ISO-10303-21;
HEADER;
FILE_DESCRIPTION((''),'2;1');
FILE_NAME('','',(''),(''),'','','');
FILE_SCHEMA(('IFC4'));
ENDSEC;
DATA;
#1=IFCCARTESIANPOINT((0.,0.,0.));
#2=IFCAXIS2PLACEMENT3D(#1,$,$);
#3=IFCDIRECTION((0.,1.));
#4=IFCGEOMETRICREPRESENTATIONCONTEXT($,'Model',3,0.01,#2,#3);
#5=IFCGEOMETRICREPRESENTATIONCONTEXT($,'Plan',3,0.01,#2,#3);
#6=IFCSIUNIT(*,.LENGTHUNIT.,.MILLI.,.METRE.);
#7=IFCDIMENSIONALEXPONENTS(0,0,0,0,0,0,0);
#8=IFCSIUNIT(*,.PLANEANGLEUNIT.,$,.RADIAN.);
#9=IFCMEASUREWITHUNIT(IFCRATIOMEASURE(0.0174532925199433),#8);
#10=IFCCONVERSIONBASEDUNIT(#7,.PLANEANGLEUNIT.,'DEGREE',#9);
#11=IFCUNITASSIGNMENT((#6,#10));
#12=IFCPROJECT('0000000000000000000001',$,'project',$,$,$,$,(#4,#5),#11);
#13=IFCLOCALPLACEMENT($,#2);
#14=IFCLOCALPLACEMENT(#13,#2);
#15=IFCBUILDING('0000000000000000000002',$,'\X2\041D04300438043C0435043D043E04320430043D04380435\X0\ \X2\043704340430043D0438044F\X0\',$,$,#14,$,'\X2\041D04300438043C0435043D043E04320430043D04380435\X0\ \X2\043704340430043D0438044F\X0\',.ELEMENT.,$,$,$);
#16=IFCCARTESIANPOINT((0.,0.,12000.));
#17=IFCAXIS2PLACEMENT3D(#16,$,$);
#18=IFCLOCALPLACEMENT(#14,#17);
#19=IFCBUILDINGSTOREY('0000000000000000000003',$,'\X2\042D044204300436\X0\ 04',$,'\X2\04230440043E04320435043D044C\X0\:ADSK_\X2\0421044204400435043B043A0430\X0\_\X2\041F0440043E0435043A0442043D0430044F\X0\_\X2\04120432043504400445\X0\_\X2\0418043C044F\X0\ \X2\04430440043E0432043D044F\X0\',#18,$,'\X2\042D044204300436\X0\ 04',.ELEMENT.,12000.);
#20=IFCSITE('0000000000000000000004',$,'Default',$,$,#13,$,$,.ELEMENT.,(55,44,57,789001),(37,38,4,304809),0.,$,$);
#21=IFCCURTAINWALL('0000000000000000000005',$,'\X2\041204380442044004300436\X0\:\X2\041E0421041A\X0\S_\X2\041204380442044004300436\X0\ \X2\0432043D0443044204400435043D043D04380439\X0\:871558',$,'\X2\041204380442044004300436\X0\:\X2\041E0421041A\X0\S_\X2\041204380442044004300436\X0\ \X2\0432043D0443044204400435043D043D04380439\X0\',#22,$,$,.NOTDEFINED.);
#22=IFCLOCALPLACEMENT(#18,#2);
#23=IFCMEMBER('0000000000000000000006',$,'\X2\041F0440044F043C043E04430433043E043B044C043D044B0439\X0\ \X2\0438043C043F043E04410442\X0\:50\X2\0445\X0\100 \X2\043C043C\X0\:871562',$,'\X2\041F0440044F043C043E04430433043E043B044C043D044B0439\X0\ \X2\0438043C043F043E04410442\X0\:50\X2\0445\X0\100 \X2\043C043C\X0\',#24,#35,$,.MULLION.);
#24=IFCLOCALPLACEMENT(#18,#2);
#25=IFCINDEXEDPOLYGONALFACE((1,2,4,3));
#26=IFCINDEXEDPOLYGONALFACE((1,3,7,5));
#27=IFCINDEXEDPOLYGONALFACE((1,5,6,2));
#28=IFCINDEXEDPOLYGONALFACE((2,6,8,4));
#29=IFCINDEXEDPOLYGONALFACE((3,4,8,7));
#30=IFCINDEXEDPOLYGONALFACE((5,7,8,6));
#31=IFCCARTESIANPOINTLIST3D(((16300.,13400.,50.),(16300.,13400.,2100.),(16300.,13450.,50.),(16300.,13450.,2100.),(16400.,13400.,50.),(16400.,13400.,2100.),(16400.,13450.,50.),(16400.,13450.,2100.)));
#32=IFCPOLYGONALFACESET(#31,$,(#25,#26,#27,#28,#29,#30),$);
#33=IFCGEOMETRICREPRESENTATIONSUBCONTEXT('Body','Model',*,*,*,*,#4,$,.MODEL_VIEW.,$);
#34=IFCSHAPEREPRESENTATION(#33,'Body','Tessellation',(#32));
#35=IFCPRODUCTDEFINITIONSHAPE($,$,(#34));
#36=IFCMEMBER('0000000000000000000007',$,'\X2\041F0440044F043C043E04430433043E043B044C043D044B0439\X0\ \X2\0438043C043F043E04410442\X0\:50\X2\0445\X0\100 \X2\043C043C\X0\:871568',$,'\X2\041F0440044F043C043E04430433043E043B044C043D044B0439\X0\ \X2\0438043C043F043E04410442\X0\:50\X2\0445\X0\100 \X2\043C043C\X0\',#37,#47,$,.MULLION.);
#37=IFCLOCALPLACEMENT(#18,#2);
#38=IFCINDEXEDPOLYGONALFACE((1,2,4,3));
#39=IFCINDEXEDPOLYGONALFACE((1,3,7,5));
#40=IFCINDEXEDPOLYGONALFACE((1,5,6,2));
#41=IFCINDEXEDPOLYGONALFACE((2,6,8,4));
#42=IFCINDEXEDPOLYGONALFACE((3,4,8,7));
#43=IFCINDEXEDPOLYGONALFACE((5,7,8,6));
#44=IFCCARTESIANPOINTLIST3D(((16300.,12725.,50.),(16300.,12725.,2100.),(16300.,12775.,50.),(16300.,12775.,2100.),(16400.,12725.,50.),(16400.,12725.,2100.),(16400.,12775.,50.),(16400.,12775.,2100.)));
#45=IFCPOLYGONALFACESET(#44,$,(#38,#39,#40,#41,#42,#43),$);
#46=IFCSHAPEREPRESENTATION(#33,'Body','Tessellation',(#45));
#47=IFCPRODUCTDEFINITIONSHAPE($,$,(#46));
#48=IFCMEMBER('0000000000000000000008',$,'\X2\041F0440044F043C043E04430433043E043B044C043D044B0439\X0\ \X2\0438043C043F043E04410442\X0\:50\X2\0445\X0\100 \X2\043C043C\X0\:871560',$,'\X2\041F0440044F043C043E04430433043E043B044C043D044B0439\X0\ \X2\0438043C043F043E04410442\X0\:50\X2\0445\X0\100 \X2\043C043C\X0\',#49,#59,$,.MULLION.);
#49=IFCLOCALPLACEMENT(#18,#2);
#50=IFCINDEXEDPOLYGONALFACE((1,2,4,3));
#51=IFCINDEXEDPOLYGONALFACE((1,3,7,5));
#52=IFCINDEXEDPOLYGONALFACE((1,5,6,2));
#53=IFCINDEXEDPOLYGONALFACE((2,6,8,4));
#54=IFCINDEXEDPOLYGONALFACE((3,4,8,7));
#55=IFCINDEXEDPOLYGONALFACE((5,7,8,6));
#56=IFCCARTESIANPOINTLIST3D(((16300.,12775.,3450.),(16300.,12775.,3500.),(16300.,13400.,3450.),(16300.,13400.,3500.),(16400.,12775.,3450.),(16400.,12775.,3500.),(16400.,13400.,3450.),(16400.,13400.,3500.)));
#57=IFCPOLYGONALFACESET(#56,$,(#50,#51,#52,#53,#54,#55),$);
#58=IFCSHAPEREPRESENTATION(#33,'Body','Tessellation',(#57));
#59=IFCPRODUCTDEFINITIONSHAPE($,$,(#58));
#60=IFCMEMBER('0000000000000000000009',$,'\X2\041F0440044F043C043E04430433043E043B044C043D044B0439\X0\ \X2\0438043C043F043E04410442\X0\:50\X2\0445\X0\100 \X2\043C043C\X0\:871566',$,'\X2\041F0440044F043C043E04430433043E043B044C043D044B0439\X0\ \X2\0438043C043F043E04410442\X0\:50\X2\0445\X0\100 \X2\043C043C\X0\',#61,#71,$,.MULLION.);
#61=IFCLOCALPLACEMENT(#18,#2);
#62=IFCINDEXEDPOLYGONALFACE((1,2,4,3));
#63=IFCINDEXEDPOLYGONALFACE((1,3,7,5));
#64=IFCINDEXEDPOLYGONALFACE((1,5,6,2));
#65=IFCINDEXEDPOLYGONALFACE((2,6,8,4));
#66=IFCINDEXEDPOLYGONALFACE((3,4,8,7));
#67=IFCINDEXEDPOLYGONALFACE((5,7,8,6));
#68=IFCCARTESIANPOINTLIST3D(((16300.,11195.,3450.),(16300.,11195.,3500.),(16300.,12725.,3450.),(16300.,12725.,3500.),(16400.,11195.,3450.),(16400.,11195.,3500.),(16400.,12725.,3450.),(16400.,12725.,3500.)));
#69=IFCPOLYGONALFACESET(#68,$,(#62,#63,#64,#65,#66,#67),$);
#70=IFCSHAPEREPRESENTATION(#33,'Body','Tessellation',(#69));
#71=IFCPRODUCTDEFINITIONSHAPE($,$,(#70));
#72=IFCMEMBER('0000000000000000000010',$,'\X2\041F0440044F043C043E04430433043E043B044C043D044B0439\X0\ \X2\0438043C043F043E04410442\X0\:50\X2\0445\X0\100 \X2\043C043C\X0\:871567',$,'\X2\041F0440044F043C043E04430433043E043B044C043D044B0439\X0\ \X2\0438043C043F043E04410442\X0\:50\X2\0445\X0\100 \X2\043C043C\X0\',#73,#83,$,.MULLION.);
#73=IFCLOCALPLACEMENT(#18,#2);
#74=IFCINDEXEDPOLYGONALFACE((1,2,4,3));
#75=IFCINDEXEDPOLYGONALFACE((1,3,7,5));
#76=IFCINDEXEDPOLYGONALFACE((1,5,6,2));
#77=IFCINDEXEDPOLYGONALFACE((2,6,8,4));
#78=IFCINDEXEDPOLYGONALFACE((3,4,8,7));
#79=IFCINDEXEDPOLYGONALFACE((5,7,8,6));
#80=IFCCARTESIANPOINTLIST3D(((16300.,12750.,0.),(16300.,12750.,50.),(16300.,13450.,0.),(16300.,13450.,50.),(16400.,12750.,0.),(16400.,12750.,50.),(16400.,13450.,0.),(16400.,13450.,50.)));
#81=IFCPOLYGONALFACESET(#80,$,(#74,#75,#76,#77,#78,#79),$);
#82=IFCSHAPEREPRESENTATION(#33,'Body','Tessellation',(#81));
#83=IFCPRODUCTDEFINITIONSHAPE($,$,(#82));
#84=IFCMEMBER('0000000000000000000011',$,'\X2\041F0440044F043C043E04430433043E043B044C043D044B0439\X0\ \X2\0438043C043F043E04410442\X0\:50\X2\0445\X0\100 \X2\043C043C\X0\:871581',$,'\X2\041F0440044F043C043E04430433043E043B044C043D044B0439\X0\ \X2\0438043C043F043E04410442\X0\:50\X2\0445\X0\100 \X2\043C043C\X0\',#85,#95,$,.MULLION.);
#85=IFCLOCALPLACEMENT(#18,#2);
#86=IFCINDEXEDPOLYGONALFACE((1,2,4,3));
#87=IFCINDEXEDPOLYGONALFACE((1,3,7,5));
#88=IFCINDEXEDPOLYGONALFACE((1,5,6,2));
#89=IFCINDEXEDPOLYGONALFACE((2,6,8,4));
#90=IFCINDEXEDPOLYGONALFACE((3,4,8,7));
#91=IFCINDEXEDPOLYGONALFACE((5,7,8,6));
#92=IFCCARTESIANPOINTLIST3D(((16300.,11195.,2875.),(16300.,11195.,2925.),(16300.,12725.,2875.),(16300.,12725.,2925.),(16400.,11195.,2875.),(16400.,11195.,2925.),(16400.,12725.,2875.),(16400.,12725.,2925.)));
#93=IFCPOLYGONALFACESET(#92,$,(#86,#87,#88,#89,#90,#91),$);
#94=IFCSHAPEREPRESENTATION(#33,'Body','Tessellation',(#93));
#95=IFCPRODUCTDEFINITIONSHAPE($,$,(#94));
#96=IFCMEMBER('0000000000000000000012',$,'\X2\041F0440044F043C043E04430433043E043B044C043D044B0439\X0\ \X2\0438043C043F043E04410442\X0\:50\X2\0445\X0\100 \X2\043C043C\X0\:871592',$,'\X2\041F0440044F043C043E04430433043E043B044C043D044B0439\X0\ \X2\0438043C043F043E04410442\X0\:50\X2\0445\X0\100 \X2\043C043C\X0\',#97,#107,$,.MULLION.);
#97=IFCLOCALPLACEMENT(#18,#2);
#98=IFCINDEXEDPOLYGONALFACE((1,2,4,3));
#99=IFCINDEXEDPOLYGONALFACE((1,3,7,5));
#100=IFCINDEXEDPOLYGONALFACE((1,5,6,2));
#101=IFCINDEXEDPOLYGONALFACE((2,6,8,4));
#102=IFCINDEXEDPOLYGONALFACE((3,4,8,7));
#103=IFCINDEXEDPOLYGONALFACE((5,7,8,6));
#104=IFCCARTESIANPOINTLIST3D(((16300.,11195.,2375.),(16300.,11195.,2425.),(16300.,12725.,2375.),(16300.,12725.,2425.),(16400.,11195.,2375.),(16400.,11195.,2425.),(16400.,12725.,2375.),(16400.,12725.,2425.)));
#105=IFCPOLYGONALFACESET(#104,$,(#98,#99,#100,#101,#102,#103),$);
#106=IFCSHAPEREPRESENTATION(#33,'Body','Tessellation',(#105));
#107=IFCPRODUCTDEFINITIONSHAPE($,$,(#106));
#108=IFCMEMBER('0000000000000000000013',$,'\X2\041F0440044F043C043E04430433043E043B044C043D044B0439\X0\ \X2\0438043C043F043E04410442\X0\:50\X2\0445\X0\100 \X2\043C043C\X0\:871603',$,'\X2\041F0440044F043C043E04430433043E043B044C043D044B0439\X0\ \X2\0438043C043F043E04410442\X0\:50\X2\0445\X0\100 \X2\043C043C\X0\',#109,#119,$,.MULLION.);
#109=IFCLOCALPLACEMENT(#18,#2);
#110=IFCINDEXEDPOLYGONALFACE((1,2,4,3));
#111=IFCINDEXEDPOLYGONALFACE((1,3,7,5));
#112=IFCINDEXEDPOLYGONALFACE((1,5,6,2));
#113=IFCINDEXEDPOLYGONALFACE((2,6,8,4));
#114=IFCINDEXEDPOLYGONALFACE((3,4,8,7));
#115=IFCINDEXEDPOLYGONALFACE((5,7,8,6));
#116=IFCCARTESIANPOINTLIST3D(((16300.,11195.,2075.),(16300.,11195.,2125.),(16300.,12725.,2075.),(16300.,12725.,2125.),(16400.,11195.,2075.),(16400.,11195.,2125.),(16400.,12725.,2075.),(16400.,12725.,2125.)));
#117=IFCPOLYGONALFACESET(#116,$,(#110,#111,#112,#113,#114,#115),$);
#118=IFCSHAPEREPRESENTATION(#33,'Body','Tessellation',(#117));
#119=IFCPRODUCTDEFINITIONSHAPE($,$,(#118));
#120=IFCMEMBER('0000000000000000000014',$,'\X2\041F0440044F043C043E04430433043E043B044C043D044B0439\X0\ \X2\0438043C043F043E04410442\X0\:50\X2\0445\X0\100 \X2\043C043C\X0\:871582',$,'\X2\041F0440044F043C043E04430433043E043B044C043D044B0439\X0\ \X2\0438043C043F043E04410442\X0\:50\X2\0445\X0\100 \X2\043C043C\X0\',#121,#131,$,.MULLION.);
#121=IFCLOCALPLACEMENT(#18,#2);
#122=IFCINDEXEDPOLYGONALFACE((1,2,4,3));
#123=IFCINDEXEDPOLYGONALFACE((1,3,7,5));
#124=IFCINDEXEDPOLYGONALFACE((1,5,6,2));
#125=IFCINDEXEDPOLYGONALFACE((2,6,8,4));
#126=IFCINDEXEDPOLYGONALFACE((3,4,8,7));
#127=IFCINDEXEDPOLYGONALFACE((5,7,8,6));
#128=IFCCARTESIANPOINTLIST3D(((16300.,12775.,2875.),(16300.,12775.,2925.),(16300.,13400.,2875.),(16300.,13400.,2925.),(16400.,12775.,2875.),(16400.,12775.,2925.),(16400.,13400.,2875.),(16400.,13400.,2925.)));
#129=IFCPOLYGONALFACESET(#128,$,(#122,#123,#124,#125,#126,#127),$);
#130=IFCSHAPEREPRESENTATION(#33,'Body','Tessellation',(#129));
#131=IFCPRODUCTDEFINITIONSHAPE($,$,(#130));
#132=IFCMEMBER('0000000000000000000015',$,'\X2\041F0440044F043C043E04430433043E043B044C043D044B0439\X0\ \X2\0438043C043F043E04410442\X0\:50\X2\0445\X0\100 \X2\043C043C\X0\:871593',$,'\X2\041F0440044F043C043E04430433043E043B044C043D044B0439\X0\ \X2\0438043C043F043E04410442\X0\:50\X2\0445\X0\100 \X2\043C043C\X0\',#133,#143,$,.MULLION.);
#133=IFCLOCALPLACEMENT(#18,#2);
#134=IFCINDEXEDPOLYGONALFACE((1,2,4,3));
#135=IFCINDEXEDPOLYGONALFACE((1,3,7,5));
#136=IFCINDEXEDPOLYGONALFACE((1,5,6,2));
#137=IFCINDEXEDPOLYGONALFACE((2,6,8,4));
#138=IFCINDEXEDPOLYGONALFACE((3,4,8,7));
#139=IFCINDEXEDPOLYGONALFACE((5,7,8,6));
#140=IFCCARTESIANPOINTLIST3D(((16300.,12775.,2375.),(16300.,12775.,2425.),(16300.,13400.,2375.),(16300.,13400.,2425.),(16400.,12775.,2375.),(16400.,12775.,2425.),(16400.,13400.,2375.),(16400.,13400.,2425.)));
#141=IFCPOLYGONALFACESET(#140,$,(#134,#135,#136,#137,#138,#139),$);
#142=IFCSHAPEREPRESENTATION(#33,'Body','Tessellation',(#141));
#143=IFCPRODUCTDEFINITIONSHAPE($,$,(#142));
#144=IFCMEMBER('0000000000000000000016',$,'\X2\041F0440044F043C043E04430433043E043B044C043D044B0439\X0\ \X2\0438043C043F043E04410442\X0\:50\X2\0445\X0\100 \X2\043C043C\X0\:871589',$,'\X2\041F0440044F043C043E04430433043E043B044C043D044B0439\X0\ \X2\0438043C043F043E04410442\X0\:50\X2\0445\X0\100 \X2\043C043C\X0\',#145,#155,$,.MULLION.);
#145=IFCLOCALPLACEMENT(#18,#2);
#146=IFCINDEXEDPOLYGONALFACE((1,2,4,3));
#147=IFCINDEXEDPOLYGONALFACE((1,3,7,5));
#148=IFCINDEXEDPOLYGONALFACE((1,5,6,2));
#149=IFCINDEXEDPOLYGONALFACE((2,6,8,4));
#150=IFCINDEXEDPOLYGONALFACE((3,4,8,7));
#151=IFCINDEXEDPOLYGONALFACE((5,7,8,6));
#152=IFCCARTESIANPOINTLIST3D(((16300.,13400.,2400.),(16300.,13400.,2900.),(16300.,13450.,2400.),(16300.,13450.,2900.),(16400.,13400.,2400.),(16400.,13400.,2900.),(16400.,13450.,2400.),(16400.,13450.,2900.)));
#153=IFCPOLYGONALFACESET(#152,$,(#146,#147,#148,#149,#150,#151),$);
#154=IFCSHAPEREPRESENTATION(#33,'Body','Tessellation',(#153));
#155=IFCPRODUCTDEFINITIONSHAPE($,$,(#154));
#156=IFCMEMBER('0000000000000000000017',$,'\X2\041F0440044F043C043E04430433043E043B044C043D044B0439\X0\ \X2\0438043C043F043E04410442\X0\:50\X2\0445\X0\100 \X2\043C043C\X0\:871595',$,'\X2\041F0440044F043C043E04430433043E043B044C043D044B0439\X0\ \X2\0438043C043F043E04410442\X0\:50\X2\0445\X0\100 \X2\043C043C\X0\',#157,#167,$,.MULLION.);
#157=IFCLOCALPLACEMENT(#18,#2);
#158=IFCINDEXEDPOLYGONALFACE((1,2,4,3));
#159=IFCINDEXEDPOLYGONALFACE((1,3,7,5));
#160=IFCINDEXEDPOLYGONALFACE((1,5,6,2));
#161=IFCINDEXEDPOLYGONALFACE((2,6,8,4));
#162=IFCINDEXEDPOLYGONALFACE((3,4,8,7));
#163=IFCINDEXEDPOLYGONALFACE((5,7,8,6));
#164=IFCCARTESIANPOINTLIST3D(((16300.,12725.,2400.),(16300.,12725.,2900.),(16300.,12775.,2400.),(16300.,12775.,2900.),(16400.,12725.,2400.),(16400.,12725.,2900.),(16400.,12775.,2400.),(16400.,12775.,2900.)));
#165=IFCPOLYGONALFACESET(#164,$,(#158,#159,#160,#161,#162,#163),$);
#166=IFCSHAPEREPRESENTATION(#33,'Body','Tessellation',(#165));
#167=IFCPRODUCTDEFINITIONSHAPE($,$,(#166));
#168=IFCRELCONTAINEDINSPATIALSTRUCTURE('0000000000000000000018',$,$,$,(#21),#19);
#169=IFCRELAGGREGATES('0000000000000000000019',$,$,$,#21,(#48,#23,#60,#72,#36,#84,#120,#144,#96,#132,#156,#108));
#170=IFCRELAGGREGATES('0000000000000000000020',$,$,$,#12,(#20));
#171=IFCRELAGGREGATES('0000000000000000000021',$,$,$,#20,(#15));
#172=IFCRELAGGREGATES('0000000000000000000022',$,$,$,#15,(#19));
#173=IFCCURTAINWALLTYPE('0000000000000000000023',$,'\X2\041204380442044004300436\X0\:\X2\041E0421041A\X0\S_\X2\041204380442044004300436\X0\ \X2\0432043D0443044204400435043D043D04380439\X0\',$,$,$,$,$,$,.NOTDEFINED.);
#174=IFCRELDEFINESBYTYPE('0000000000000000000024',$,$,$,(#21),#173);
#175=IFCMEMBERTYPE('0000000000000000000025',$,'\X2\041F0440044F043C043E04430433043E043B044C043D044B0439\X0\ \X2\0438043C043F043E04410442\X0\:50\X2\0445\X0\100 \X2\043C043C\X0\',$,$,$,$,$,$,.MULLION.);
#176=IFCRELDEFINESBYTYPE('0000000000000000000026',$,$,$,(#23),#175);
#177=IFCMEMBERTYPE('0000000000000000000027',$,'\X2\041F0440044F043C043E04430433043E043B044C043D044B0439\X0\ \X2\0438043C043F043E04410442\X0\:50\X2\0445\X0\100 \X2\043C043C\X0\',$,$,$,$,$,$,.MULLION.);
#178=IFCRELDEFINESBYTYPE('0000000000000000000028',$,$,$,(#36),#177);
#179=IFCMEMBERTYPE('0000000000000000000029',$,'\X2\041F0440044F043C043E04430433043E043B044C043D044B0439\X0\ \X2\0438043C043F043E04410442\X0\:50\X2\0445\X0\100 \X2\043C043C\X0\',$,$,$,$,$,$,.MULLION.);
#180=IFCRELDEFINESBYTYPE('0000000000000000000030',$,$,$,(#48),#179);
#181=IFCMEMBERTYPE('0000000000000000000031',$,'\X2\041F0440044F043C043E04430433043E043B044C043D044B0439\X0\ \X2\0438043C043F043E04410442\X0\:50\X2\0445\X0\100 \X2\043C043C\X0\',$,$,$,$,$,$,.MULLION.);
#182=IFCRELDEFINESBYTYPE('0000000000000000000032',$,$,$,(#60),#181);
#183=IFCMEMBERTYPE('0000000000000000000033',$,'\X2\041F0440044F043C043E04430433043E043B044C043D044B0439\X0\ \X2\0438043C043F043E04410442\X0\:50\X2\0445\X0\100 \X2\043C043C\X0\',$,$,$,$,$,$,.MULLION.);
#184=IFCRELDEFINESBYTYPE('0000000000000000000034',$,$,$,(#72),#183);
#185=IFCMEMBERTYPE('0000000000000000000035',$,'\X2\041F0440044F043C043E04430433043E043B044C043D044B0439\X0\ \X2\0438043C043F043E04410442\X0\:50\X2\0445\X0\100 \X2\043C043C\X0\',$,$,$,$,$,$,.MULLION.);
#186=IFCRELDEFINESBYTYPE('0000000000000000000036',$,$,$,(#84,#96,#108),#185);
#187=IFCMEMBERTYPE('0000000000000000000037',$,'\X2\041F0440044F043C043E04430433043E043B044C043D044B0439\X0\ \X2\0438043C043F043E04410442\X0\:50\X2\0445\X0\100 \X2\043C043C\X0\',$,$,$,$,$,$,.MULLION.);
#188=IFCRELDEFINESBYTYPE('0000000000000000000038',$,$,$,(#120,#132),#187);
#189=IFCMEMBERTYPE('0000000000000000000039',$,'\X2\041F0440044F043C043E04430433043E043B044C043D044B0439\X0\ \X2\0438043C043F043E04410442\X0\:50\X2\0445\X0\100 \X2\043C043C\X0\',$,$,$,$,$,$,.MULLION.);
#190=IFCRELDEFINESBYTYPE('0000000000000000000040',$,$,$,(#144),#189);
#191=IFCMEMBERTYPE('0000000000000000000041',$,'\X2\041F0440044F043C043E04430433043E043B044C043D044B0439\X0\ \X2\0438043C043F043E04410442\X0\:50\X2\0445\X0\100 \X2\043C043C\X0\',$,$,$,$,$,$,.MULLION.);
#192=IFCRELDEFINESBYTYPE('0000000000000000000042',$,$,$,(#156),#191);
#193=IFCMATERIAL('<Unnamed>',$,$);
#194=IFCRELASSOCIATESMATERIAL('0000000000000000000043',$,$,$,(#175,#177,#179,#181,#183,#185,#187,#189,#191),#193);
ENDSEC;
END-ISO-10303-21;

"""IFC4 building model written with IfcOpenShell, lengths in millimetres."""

from ifc_helpers import new_model, entity, si_unit, converted_unit, direction, frame, origin, place, context, subcontext, project, spatial, indexed_curve, outline, extrude, source, transform, mapped, material, type_object, type_shapes, element, aggregate, save


model = new_model("IFC4")

# Units and contexts
model_context = context("Model", 3, precision=0.01, world=origin(), true_north=direction((0.0, 1.0)))
plan_context = context("Plan", 3, precision=0.01, world=origin(), true_north=direction((0.0, 1.0)))
body_context = subcontext(model_context, "Body", "Model", "MODEL_VIEW")
ifc_project = project(units=[si_unit("LENGTHUNIT", "METRE", prefix="MILLI"), converted_unit("PLANEANGLEUNIT", "DEGREE", entity("IfcRatioMeasure", 0.0174532925199433), si_unit("PLANEANGLEUNIT", "RADIAN"), dimensions=[0, 0, 0, 0, 0, 0, 0])], contexts=[model_context, plan_context])

# Site, building, storey
site_placement = place(None, frame((0.0, 0.0, 0.0)))
site = spatial("IfcSite", under=ifc_project, at=site_placement, Name="Default", CompositionType="ELEMENT", RefLatitude=(55, 44, 57, 789001), RefLongitude=(37, 38, 4, 304809), RefElevation=0.0)
building_placement = place(site_placement, origin())
building = spatial("IfcBuilding", under=site, at=building_placement, Name="Наименование здания", LongName="Наименование здания", CompositionType="ELEMENT")
storey_placement = place(building_placement, frame((0.0, 0.0, 12000.0)))
storey = spatial("IfcBuildingStorey", under=building, at=storey_placement, Name="Этаж 04", ObjectType="Уровень:ADSK_Стрелка_Проектная_Вверх_Имя уровня", LongName="Этаж 04", CompositionType="ELEMENT", Elevation=12000.0)

# Curtain wall, members
curtain_wall_type = type_object("IfcCurtainWallType", Name="Витраж:ОСКS_Витраж внутренний", PredefinedType="NOTDEFINED")
curtain_wall_placement = place(storey_placement, frame((0.0, 0.0, -12000.0)))
curtain_wall = element("IfcCurtainWall", 1, at=curtain_wall_placement, inside=storey, type_object=curtain_wall_type, Name="Витраж:ОСКS_Витраж внутренний:871558", ObjectType="Витраж:ОСКS_Витраж внутренний", PredefinedType="NOTDEFINED")
ifc_material_1 = material(Name="<Unnamed>")
member_type_1 = type_object("IfcMemberType", Name="Прямоугольный импост:50х100 мм", PredefinedType="MULLION", material=ifc_material_1)
shared_shape_1 = source(origin(), body_context, "Body", "SweptSolid", [
    extrude(outline(indexed_curve([(-50.0, -25.0), (50.0, -25.0), (50.0, 25.0), (-50.0, 25.0), (-50.0, -25.0)], self_intersect=False)), frame((-25.0, 0.0, -2050.0), z_axis=(0.0, 0.0, 1.0), x_axis=(0.0, -1.0, 0.0)), (0.0, 0.0, 1.0), 2050.0),
])
type_shapes(member_type_1, [shared_shape_1])
member_1_placement = place(storey_placement, frame((16350.0, 13450.0, 50.0), z_axis=(0.0, 0.0, -1.0), x_axis=(0.0, 1.0, 0.0)))
member_1 = element("IfcMember", 2, at=member_1_placement, type_object=member_type_1, Name="Прямоугольный импост:50х100 мм:871562", ObjectType="Прямоугольный импост:50х100 мм", PredefinedType="MULLION", context=body_context, shape_type="MappedRepresentation", body=[
    mapped(shared_shape_1, transform((0.0, 0.0, 0.0), scale=1.0)),
])
member_type_2 = type_object("IfcMemberType", Name="Прямоугольный импост:50х100 мм", PredefinedType="MULLION", material=ifc_material_1)
shared_shape_2 = source(origin(), body_context, "Body", "SweptSolid", [
    extrude(outline(indexed_curve([(-50.0, -25.0), (50.0, -25.0), (50.0, 25.0), (-50.0, 25.0), (-50.0, -25.0)], self_intersect=False)), frame((0.0, 0.0, -2050.0), z_axis=(0.0, 0.0, 1.0), x_axis=(0.0, -1.0, 0.0)), (0.0, 0.0, 1.0), 2050.0),
])
type_shapes(member_type_2, [shared_shape_2])
member_2_placement = place(storey_placement, frame((16350.0, 12750.0, 50.0), z_axis=(0.0, 0.0, -1.0), x_axis=(0.0, 1.0, 0.0)))
member_2 = element("IfcMember", 3, at=member_2_placement, type_object=member_type_2, Name="Прямоугольный импост:50х100 мм:871568", ObjectType="Прямоугольный импост:50х100 мм", PredefinedType="MULLION", context=body_context, shape_type="MappedRepresentation", body=[
    mapped(shared_shape_2, transform((0.0, 0.0, 0.0), scale=1.0)),
])
member_type_3 = type_object("IfcMemberType", Name="Прямоугольный импост:50х100 мм", PredefinedType="MULLION", material=ifc_material_1)
shared_shape_3 = source(origin(), body_context, "Body", "SweptSolid", [
    extrude(outline(indexed_curve([(-50.0, -25.0), (50.0, -25.0), (50.0, 25.0), (-50.0, 25.0), (-50.0, -25.0)], self_intersect=False)), frame((-25.0, 0.0, -625.0), z_axis=(0.0, 0.0, 1.0), x_axis=(0.0, -1.0, 0.0)), (0.0, 0.0, 1.0), 625.0),
])
type_shapes(member_type_3, [shared_shape_3])
member_3_placement = place(storey_placement, frame((16350.0, 13400.0, 3500.0), z_axis=(0.0, 1.0, 0.0), x_axis=(0.0, 0.0, 1.0)))
member_3 = element("IfcMember", 4, at=member_3_placement, type_object=member_type_3, Name="Прямоугольный импост:50х100 мм:871560", ObjectType="Прямоугольный импост:50х100 мм", PredefinedType="MULLION", context=body_context, shape_type="MappedRepresentation", body=[
    mapped(shared_shape_3, transform((0.0, 0.0, 0.0), scale=1.0)),
])
member_type_4 = type_object("IfcMemberType", Name="Прямоугольный импост:50х100 мм", PredefinedType="MULLION", material=ifc_material_1)
shared_shape_4 = source(origin(), body_context, "Body", "SweptSolid", [
    extrude(outline(indexed_curve([(-50.0, -25.0), (50.0, -25.0), (50.0, 25.0), (-50.0, 25.0), (-50.0, -25.0)], self_intersect=False)), frame((-25.0, 0.0, -1530.0), z_axis=(0.0, 0.0, 1.0), x_axis=(0.0, -1.0, 0.0)), (0.0, 0.0, 1.0), 1530.0),
])
type_shapes(member_type_4, [shared_shape_4])
member_4_placement = place(storey_placement, frame((16350.0, 12725.0, 3500.0), z_axis=(0.0, 1.0, 0.0), x_axis=(0.0, 0.0, 1.0)))
member_4 = element("IfcMember", 5, at=member_4_placement, type_object=member_type_4, Name="Прямоугольный импост:50х100 мм:871566", ObjectType="Прямоугольный импост:50х100 мм", PredefinedType="MULLION", context=body_context, shape_type="MappedRepresentation", body=[
    mapped(shared_shape_4, transform((0.0, 0.0, 0.0), scale=1.0)),
])
member_type_5 = type_object("IfcMemberType", Name="Прямоугольный импост:50х100 мм", PredefinedType="MULLION", material=ifc_material_1)
shared_shape_5 = source(origin(), body_context, "Body", "SweptSolid", [
    extrude(outline(indexed_curve([(-50.0, -25.0), (50.0, -25.0), (50.0, 25.0), (-50.0, 25.0), (-50.0, -25.0)], self_intersect=False)), frame((-25.0, 0.0, -700.0), z_axis=(0.0, 0.0, 1.0), x_axis=(0.0, -1.0, 0.0)), (0.0, 0.0, 1.0), 700.0),
])
type_shapes(member_type_5, [shared_shape_5])
member_5_placement = place(storey_placement, frame((16350.0, 12750.0, 0.0), z_axis=(0.0, -1.0, 0.0), x_axis=(0.0, 0.0, -1.0)))
member_5 = element("IfcMember", 6, at=member_5_placement, type_object=member_type_5, Name="Прямоугольный импост:50х100 мм:871567", ObjectType="Прямоугольный импост:50х100 мм", PredefinedType="MULLION", context=body_context, shape_type="MappedRepresentation", body=[
    mapped(shared_shape_5, transform((0.0, 0.0, 0.0), scale=1.0)),
])
member_type_6 = type_object("IfcMemberType", Name="Прямоугольный импост:50х100 мм", PredefinedType="MULLION", material=ifc_material_1)
shared_shape_6 = source(origin(), body_context, "Body", "SweptSolid", [
    extrude(outline(indexed_curve([(-50.0, -25.0), (50.0, -25.0), (50.0, 25.0), (-50.0, 25.0), (-50.0, -25.0)], self_intersect=False)), frame((0.0, 0.0, -1530.0), z_axis=(0.0, 0.0, 1.0), x_axis=(0.0, -1.0, 0.0)), (0.0, 0.0, 1.0), 1530.0),
])
type_shapes(member_type_6, [shared_shape_6])
member_6_placement = place(storey_placement, frame((16350.0, 12725.0, 2900.0), z_axis=(0.0, 1.0, 0.0), x_axis=(0.0, 0.0, 1.0)))
member_6 = element("IfcMember", 7, at=member_6_placement, type_object=member_type_6, Name="Прямоугольный импост:50х100 мм:871581", ObjectType="Прямоугольный импост:50х100 мм", PredefinedType="MULLION", context=body_context, shape_type="MappedRepresentation", body=[
    mapped(shared_shape_6, transform((0.0, 0.0, 0.0), scale=1.0)),
])
member_7_placement = place(storey_placement, frame((16350.0, 12725.0, 2400.0), z_axis=(0.0, 1.0, 0.0), x_axis=(0.0, 0.0, 1.0)))
member_7 = element("IfcMember", 8, at=member_7_placement, type_object=member_type_6, Name="Прямоугольный импост:50х100 мм:871592", ObjectType="Прямоугольный импост:50х100 мм", PredefinedType="MULLION", context=body_context, shape_type="MappedRepresentation", body=[
    mapped(shared_shape_6, transform((0.0, 0.0, 0.0), scale=1.0)),
])
member_8_placement = place(storey_placement, frame((16350.0, 12725.0, 2100.0), z_axis=(0.0, 1.0, 0.0), x_axis=(0.0, 0.0, 1.0)))
member_8 = element("IfcMember", 9, at=member_8_placement, type_object=member_type_6, Name="Прямоугольный импост:50х100 мм:871603", ObjectType="Прямоугольный импост:50х100 мм", PredefinedType="MULLION", context=body_context, shape_type="MappedRepresentation", body=[
    mapped(shared_shape_6, transform((0.0, 0.0, 0.0), scale=1.0)),
])
member_type_7 = type_object("IfcMemberType", Name="Прямоугольный импост:50х100 мм", PredefinedType="MULLION", material=ifc_material_1)
shared_shape_7 = source(origin(), body_context, "Body", "SweptSolid", [
    extrude(outline(indexed_curve([(-50.0, -25.0), (50.0, -25.0), (50.0, 25.0), (-50.0, 25.0), (-50.0, -25.0)], self_intersect=False)), frame((0.0, 0.0, -625.0), z_axis=(0.0, 0.0, 1.0), x_axis=(0.0, -1.0, 0.0)), (0.0, 0.0, 1.0), 625.0),
])
type_shapes(member_type_7, [shared_shape_7])
member_9_placement = place(storey_placement, frame((16350.0, 13400.0, 2900.0), z_axis=(0.0, 1.0, 0.0), x_axis=(0.0, 0.0, 1.0)))
member_9 = element("IfcMember", 10, at=member_9_placement, type_object=member_type_7, Name="Прямоугольный импост:50х100 мм:871582", ObjectType="Прямоугольный импост:50х100 мм", PredefinedType="MULLION", context=body_context, shape_type="MappedRepresentation", body=[
    mapped(shared_shape_7, transform((0.0, 0.0, 0.0), scale=1.0)),
])
member_10_placement = place(storey_placement, frame((16350.0, 13400.0, 2400.0), z_axis=(0.0, 1.0, 0.0), x_axis=(0.0, 0.0, 1.0)))
member_10 = element("IfcMember", 11, at=member_10_placement, type_object=member_type_7, Name="Прямоугольный импост:50х100 мм:871593", ObjectType="Прямоугольный импост:50х100 мм", PredefinedType="MULLION", context=body_context, shape_type="MappedRepresentation", body=[
    mapped(shared_shape_7, transform((0.0, 0.0, 0.0), scale=1.0)),
])
member_type_8 = type_object("IfcMemberType", Name="Прямоугольный импост:50х100 мм", PredefinedType="MULLION", material=ifc_material_1)
shared_shape_8 = source(origin(), body_context, "Body", "SweptSolid", [
    extrude(outline(indexed_curve([(-50.0, -25.0), (50.0, -25.0), (50.0, 25.0), (-50.0, 25.0), (-50.0, -25.0)], self_intersect=False)), frame((-25.0, 0.0, -500.0), z_axis=(0.0, 0.0, 1.0), x_axis=(0.0, -1.0, 0.0)), (0.0, 0.0, 1.0), 500.0),
])
type_shapes(member_type_8, [shared_shape_8])
member_11_placement = place(storey_placement, frame((16350.0, 13450.0, 2400.0), z_axis=(0.0, 0.0, -1.0), x_axis=(0.0, 1.0, 0.0)))
member_11 = element("IfcMember", 12, at=member_11_placement, type_object=member_type_8, Name="Прямоугольный импост:50х100 мм:871589", ObjectType="Прямоугольный импост:50х100 мм", PredefinedType="MULLION", context=body_context, shape_type="MappedRepresentation", body=[
    mapped(shared_shape_8, transform((0.0, 0.0, 0.0), scale=1.0)),
])
member_type_9 = type_object("IfcMemberType", Name="Прямоугольный импост:50х100 мм", PredefinedType="MULLION", material=ifc_material_1)
shared_shape_9 = source(origin(), body_context, "Body", "SweptSolid", [
    extrude(outline(indexed_curve([(-50.0, -25.0), (50.0, -25.0), (50.0, 25.0), (-50.0, 25.0), (-50.0, -25.0)], self_intersect=False)), frame((0.0, 0.0, -500.0), z_axis=(0.0, 0.0, 1.0), x_axis=(0.0, -1.0, 0.0)), (0.0, 0.0, 1.0), 500.0),
])
type_shapes(member_type_9, [shared_shape_9])
member_12_placement = place(storey_placement, frame((16350.0, 12750.0, 2400.0), z_axis=(0.0, 0.0, -1.0), x_axis=(0.0, 1.0, 0.0)))
member_12 = element("IfcMember", 13, at=member_12_placement, type_object=member_type_9, Name="Прямоугольный импост:50х100 мм:871595", ObjectType="Прямоугольный импост:50х100 мм", PredefinedType="MULLION", context=body_context, shape_type="MappedRepresentation", body=[
    mapped(shared_shape_9, transform((0.0, 0.0, 0.0), scale=1.0)),
])

aggregate(curtain_wall, [member_3, member_1, member_4, member_5, member_2, member_6, member_9, member_11, member_7, member_10, member_12, member_8])

save(model, "model.ifc")
